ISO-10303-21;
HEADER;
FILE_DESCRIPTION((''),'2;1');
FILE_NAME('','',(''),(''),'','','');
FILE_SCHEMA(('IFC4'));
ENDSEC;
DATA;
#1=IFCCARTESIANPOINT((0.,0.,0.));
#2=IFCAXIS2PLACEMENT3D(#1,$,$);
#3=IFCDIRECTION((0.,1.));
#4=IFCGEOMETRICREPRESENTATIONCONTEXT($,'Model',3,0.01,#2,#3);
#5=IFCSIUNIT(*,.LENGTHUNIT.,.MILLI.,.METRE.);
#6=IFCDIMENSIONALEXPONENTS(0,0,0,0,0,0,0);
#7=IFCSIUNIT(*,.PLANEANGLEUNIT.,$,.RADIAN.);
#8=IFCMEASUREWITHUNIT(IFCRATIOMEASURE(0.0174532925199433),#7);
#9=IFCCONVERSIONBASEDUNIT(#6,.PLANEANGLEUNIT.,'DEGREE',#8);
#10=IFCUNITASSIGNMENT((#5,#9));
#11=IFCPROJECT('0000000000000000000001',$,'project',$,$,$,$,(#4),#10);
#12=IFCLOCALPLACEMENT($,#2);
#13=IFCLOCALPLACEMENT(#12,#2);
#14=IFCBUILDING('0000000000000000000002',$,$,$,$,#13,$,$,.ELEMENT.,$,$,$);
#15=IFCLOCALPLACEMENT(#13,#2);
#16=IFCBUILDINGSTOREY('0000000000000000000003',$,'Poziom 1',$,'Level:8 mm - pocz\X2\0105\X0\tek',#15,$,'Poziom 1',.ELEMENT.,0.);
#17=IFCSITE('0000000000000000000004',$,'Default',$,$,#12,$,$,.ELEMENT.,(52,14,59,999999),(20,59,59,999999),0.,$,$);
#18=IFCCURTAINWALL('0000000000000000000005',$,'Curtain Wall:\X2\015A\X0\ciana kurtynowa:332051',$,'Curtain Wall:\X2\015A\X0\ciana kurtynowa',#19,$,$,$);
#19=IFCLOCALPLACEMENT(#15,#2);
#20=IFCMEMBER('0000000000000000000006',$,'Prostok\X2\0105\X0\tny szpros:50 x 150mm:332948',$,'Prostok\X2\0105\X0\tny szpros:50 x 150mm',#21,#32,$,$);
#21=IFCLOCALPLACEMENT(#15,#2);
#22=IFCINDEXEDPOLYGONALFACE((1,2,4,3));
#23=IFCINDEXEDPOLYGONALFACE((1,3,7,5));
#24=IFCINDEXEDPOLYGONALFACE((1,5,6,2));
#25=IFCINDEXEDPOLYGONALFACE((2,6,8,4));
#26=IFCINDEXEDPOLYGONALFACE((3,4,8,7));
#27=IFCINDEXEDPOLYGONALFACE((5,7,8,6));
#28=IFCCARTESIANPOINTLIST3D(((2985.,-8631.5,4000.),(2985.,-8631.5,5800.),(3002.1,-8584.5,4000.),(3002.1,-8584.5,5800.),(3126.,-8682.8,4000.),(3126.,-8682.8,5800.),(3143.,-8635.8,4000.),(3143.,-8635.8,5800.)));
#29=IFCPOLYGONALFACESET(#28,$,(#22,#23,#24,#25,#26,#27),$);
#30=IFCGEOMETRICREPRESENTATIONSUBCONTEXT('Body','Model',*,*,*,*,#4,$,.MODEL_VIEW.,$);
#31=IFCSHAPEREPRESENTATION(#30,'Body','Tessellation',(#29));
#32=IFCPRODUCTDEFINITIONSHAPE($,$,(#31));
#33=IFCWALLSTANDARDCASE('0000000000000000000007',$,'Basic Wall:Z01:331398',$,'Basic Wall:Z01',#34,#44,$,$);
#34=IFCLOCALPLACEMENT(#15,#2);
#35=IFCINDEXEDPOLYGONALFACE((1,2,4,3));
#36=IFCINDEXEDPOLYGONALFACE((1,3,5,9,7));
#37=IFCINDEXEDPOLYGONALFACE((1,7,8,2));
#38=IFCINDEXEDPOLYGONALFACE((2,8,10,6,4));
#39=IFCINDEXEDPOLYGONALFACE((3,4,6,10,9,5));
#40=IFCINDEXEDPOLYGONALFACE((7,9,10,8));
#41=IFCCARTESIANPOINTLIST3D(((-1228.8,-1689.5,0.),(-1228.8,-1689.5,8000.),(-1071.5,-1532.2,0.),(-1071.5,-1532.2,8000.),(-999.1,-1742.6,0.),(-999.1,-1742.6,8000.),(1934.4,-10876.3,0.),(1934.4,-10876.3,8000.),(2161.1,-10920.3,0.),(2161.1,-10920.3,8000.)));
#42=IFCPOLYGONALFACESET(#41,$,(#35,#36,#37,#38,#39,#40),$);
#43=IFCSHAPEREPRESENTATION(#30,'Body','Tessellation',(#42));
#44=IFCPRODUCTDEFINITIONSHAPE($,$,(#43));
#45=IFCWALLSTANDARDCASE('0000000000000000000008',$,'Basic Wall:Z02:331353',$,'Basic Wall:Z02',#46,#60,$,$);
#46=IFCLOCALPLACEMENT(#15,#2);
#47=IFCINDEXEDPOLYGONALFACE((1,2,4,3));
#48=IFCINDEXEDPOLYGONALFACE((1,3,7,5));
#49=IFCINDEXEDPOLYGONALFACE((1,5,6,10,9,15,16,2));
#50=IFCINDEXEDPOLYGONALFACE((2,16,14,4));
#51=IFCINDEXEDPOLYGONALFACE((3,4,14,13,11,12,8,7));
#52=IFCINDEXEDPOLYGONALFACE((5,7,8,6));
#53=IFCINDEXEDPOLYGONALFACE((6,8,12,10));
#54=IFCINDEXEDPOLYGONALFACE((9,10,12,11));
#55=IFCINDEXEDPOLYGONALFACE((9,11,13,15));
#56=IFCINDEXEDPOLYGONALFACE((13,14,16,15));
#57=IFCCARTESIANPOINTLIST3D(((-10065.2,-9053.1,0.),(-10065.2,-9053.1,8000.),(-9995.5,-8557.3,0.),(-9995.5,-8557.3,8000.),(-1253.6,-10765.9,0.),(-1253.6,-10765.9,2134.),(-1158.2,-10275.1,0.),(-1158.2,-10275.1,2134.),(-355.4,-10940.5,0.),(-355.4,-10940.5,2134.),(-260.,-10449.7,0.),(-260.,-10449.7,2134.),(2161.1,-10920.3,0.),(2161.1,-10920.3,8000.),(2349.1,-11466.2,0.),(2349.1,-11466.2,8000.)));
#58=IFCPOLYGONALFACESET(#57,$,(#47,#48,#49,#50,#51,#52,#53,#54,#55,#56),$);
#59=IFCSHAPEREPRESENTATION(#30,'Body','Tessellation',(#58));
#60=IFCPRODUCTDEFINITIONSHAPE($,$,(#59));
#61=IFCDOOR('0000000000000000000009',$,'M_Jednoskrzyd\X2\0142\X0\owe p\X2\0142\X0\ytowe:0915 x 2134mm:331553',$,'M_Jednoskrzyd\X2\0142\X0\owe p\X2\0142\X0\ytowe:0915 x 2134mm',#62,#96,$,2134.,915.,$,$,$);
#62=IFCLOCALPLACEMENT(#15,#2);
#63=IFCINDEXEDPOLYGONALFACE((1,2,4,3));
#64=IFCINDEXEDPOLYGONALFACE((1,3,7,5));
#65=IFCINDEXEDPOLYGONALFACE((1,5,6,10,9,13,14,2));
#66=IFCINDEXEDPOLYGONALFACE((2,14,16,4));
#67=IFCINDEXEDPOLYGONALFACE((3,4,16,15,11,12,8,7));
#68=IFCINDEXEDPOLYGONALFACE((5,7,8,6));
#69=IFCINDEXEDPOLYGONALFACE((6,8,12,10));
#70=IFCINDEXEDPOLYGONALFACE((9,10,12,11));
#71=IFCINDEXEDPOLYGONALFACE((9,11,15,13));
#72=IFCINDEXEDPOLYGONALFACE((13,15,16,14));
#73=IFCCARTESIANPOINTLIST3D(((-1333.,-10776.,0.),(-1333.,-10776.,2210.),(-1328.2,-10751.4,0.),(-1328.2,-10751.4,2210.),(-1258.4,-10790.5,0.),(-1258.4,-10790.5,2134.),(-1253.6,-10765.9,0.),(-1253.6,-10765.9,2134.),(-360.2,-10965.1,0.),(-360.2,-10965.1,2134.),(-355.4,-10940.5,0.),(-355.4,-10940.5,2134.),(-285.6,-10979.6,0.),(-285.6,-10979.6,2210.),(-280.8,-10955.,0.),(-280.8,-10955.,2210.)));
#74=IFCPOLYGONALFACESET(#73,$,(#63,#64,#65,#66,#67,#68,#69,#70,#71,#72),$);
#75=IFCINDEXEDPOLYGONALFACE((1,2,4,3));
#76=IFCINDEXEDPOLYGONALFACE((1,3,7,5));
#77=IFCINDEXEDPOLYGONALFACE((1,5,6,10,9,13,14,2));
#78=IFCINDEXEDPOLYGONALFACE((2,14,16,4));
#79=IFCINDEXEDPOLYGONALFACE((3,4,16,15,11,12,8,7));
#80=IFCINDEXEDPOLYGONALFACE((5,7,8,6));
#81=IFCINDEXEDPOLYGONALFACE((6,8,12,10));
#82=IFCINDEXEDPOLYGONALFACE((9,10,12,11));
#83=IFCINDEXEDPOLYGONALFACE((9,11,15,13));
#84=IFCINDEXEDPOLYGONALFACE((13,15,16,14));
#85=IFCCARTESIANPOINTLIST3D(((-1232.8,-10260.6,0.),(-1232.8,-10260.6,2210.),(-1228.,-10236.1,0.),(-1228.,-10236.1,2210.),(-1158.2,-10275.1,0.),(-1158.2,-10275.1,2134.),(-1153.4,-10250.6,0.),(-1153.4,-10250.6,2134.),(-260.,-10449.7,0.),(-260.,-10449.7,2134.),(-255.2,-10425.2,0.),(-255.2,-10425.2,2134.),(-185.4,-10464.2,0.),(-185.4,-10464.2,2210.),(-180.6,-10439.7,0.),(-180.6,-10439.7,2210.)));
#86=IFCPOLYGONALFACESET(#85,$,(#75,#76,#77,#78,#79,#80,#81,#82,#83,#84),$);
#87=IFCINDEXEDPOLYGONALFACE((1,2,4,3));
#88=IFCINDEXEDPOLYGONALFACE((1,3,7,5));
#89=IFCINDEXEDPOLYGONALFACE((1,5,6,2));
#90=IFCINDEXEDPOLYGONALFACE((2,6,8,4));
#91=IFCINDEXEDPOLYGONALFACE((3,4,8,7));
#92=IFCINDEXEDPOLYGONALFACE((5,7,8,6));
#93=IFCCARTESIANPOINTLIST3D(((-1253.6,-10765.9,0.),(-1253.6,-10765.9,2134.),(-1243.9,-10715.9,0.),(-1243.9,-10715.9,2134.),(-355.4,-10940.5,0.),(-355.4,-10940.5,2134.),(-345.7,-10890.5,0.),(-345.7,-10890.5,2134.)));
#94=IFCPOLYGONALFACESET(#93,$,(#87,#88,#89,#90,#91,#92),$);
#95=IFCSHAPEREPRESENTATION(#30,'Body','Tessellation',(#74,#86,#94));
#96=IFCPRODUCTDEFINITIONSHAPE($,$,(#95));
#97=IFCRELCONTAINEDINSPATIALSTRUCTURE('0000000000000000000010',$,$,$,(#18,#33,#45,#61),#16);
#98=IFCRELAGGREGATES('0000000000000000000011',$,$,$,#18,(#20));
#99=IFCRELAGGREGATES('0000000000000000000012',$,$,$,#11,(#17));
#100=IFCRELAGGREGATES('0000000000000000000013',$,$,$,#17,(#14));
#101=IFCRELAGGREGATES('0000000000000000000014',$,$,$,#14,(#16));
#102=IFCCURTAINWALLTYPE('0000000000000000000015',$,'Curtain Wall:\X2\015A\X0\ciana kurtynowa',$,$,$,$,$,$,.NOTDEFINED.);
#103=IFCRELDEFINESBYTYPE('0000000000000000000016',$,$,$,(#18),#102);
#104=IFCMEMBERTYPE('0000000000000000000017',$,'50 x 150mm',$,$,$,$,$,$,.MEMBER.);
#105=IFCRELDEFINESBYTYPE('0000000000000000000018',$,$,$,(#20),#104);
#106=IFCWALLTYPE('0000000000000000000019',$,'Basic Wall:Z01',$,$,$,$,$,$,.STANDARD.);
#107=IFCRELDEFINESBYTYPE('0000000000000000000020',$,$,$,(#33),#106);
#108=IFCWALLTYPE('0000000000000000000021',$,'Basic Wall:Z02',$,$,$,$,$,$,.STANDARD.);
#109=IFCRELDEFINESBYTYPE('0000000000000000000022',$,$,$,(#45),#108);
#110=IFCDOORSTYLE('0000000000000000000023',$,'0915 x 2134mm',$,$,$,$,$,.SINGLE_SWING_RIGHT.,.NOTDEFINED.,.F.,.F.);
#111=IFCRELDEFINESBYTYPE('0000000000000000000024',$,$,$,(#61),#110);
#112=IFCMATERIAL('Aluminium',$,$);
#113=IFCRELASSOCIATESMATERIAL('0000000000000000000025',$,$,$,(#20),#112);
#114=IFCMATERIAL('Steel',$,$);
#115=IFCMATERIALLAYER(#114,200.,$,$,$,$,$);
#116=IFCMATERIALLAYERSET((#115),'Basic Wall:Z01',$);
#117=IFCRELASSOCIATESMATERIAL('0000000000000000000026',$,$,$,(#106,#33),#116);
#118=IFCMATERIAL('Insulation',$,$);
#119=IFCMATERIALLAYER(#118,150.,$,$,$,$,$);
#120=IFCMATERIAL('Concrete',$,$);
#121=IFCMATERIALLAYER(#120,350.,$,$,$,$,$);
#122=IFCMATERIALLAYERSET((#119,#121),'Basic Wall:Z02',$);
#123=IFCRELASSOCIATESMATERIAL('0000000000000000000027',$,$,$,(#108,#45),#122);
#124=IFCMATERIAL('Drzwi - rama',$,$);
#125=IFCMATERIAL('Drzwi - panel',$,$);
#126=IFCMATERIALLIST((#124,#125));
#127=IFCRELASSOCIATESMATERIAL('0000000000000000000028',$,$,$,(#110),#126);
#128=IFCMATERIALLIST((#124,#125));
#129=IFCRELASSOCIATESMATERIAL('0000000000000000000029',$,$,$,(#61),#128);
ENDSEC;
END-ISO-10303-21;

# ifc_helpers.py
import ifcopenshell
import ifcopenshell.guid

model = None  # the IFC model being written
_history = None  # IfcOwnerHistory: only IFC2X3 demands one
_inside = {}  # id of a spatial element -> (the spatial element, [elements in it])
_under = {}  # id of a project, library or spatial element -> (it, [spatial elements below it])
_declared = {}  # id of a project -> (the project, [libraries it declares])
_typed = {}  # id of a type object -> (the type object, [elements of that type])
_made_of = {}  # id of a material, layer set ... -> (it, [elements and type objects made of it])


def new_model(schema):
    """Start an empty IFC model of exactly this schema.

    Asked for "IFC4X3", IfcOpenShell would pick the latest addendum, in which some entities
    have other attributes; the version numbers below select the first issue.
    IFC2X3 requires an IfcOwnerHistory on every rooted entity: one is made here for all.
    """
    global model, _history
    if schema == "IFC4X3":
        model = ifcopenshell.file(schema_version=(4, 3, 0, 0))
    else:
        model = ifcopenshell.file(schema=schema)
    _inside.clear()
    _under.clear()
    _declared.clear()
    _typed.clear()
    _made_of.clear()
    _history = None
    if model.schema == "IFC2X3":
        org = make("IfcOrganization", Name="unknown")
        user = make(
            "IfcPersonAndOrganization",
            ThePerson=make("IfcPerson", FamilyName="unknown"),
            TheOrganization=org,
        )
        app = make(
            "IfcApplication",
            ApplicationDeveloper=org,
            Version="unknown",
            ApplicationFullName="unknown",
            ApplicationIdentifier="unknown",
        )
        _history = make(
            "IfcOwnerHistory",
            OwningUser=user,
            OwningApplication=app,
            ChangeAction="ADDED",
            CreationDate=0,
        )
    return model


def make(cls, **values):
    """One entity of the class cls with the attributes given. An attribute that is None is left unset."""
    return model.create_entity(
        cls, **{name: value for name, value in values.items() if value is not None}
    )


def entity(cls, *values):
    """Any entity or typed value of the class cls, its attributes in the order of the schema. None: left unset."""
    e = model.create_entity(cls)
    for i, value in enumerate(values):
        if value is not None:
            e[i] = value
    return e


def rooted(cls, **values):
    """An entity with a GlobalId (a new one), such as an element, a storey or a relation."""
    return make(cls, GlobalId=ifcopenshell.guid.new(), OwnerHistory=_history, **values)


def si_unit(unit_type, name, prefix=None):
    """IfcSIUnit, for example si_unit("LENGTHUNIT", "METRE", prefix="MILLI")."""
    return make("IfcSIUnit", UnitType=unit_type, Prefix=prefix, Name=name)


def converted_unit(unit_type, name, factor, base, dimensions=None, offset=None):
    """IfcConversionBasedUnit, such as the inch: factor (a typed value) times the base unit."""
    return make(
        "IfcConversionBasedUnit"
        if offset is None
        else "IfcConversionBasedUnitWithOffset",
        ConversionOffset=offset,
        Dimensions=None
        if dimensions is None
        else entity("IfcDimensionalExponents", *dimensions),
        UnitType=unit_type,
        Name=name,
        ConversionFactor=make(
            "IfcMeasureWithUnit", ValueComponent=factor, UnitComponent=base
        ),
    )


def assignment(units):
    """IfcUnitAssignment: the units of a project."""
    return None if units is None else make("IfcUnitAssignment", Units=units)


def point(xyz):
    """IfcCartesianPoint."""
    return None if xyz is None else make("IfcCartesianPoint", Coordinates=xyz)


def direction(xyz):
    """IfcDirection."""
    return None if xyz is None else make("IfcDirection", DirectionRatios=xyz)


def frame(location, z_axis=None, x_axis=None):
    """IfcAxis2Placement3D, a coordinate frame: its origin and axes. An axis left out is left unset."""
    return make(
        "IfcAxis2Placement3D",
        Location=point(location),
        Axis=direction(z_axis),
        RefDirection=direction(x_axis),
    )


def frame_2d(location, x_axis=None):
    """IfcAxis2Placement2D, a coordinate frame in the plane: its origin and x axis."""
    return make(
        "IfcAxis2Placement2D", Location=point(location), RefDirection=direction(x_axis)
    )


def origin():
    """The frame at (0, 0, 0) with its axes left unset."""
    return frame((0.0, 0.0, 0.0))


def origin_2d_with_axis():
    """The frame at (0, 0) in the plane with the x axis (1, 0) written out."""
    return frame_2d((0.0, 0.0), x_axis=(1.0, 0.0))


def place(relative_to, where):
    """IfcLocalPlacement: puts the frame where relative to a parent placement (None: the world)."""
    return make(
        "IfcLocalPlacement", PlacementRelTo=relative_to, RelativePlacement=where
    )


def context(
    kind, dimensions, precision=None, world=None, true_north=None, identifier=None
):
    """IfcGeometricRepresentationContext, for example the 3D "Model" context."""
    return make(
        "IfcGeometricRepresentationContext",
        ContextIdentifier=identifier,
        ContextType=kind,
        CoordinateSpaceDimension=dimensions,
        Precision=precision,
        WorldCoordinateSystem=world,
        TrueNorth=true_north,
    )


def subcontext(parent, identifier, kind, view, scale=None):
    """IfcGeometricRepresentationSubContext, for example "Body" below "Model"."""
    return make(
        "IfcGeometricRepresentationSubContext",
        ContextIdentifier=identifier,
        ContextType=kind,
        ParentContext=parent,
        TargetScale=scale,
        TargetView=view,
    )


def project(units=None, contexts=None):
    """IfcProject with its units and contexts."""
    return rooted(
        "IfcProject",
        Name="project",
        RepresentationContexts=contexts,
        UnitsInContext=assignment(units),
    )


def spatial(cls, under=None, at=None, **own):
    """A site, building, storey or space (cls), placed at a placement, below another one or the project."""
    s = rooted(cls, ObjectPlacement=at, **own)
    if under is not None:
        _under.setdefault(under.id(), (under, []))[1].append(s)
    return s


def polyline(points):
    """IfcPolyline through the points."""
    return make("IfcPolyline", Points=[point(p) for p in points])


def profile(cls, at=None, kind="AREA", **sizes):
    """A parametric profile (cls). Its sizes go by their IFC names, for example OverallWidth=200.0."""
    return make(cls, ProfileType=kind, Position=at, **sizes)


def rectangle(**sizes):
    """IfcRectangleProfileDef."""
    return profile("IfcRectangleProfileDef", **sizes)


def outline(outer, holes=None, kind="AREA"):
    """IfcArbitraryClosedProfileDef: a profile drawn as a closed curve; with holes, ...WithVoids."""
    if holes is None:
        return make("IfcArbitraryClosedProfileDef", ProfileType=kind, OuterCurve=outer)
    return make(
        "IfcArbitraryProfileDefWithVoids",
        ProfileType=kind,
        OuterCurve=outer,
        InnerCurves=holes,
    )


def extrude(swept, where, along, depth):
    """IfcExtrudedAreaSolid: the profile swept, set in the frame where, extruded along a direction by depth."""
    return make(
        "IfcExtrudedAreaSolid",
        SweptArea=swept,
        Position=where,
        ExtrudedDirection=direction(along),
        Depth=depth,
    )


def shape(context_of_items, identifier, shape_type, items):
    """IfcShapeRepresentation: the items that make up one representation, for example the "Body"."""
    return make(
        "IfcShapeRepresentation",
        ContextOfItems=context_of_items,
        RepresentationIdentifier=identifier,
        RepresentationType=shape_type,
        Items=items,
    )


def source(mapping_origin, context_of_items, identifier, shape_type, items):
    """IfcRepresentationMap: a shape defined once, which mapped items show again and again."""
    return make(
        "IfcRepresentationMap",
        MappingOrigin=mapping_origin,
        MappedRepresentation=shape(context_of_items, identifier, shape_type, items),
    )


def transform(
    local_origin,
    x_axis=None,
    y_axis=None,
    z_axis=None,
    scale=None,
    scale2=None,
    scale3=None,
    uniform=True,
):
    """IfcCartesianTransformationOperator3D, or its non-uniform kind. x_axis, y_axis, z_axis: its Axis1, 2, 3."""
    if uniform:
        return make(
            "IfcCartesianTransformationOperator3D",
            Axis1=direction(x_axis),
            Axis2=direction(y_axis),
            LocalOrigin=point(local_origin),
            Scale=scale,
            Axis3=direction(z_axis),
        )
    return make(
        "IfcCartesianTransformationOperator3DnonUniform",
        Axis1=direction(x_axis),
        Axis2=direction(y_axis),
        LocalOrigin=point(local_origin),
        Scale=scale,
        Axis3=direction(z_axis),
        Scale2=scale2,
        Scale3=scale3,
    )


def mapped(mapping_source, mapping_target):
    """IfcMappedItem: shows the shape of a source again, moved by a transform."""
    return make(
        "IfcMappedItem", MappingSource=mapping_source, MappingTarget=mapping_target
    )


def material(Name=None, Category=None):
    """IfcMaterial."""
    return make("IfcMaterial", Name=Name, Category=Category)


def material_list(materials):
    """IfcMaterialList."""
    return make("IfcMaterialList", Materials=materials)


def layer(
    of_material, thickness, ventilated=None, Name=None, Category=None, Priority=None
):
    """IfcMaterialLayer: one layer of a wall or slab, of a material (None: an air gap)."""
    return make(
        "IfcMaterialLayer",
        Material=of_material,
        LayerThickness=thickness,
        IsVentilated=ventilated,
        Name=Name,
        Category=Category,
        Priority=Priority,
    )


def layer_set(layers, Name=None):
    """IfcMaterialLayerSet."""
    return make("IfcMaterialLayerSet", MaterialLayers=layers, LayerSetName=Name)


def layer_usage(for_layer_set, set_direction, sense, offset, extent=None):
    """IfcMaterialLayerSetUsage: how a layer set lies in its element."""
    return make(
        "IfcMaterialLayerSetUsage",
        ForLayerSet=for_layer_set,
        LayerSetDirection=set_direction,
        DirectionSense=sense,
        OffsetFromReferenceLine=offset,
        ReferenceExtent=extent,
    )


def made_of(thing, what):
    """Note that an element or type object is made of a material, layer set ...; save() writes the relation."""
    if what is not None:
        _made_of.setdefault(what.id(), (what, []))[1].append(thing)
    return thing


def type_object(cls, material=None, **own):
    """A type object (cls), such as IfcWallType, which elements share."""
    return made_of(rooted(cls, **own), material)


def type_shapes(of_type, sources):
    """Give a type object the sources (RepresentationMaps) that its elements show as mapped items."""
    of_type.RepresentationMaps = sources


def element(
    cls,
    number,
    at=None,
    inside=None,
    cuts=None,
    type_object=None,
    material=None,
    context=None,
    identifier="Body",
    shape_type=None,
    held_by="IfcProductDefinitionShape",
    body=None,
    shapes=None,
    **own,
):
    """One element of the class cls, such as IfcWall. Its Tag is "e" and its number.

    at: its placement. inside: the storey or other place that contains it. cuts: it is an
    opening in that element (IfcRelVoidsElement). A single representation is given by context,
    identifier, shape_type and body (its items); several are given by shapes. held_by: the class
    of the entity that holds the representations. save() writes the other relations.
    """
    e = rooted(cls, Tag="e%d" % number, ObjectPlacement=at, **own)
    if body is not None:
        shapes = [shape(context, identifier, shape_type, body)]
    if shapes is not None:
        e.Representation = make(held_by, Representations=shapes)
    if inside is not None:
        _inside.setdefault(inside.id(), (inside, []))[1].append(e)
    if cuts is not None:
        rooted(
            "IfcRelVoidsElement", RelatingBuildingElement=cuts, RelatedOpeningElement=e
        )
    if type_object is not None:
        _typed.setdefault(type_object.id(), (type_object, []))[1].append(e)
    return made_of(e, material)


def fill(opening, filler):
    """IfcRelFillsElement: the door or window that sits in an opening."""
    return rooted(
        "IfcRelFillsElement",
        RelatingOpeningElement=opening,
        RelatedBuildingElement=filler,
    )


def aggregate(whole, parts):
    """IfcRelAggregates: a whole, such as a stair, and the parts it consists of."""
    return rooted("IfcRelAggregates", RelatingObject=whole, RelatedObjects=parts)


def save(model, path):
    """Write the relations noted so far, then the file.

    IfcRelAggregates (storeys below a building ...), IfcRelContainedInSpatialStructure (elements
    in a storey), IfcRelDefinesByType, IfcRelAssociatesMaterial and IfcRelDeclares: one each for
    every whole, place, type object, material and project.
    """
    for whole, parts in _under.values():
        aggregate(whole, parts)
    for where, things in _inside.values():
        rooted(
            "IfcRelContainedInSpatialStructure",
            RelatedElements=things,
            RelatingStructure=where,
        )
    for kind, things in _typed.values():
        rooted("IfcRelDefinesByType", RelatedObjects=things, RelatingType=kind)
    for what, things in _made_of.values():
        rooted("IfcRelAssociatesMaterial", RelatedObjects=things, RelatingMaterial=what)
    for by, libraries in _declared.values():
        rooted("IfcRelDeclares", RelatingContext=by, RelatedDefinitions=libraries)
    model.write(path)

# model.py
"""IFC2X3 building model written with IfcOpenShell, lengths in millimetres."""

from ifc_helpers import new_model, entity, si_unit, converted_unit, direction, frame, frame_2d, origin, origin_2d_with_axis, place, context, subcontext, project, spatial, polyline, rectangle, outline, extrude, source, transform, mapped, material, material_list, layer, layer_set, layer_usage, type_object, type_shapes, element, fill, aggregate, save


model = new_model("IFC2X3")

# Units and contexts
model_context = context("Model", 3, precision=0.01, world=origin(), true_north=direction((0.0, 1.0)))
body_context = subcontext(model_context, "Body", "Model", "MODEL_VIEW")
ifc_project = project(units=[si_unit("LENGTHUNIT", "METRE", prefix="MILLI"), converted_unit("PLANEANGLEUNIT", "DEGREE", entity("IfcRatioMeasure", 0.0174532925199433), si_unit("PLANEANGLEUNIT", "RADIAN"), dimensions=[0, 0, 0, 0, 0, 0, 0])], contexts=[model_context])

# Site, building, storey
site_placement = place(None, origin())
site = spatial("IfcSite", under=ifc_project, at=site_placement, Name="Default", CompositionType="ELEMENT", RefLatitude=(52, 14, 59, 999999), RefLongitude=(20, 59, 59, 999999), RefElevation=0.0)
building_placement = place(site_placement, origin())
building = spatial("IfcBuilding", under=site, at=building_placement, CompositionType="ELEMENT")
storey_placement = place(building_placement, origin())
storey = spatial("IfcBuildingStorey", under=building, at=storey_placement, Name="Poziom 1", ObjectType="Level:8 mm - początek", LongName="Poziom 1", CompositionType="ELEMENT", Elevation=0.0)

# Curtain wall, member
curtain_wall_type = type_object("IfcCurtainWallType", Name="Curtain Wall:Ściana kurtynowa", PredefinedType="NOTDEFINED")
curtain_wall_placement = place(storey_placement, origin())
curtain_wall = element("IfcCurtainWall", 1, at=curtain_wall_placement, inside=storey, type_object=curtain_wall_type, Name="Curtain Wall:Ściana kurtynowa:332051", ObjectType="Curtain Wall:Ściana kurtynowa")
ifc_material_1 = material(Name="Aluminium")
member_type_1 = type_object("IfcMemberType", Name="50 x 150mm", PredefinedType="MEMBER")
shared_shape_1 = source(origin(), body_context, "Body", "SweptSolid", [
    extrude(rectangle(XDim=150.0, YDim=50.0, at=origin_2d_with_axis()), frame((0.0, 0.0, -1800.0), z_axis=(0.0, 0.0, 1.0), x_axis=(0.0, -1.0, 0.0)), (0.0, 0.0, 1.0), 1800.0),
])
type_shapes(member_type_1, [shared_shape_1])
member_1_placement = place(storey_placement, frame((3064.0, -8633.7, 4000.0), z_axis=(0.0, 0.0, -1.0), x_axis=(0.341586, 0.939851, 0.0)))
member_1 = element("IfcMember", 2, at=member_1_placement, type_object=member_type_1, material=ifc_material_1, Name="Prostokątny szpros:50 x 150mm:332948", ObjectType="Prostokątny szpros:50 x 150mm", context=body_context, shape_type="MappedRepresentation", body=[
    mapped(shared_shape_1, transform((0.0, 0.0, 0.0), scale=1.0)),
])
aggregate(curtain_wall, [member_1])

# Wall
ifc_material_2 = material(Name="Steel")
ifc_layer_1 = layer(ifc_material_2, 200.0)
ifc_layer_set_1 = layer_set([ifc_layer_1], Name="Basic Wall:Z01")
ifc_layer_usage_1 = layer_usage(ifc_layer_set_1, "AXIS2", "NEGATIVE", 100.0)
wall_type_1 = type_object("IfcWallType", Name="Basic Wall:Z01", PredefinedType="STANDARD", material=ifc_layer_set_1)
wall_1_placement = place(storey_placement, frame((2066.5, -10952.9, 0.0), z_axis=(0.0, 0.0, 1.0), x_axis=(-0.325568, 0.945519, 0.0)))
element("IfcWallStandardCase", 3, at=wall_1_placement, inside=storey, type_object=wall_type_1, material=ifc_layer_usage_1, Name="Basic Wall:Z01:331398", ObjectType="Basic Wall:Z01", context=body_context, shape_type="SweptSolid", body=[
    extrude(outline(polyline([(9929.1, -100.0), (9831.5, 100.0), (115.5, 100.0), (0.0, -100.0), (9706.6, -100.0), (9929.1, -100.0)])), origin(), (0.0, 0.0, 1.0), 8000.0),
])

# Wall, opening, door
ifc_material_3 = material(Name="Insulation")
ifc_layer_2 = layer(ifc_material_3, 150.0)
ifc_material_4 = material(Name="Concrete")
ifc_layer_3 = layer(ifc_material_4, 350.0)
ifc_layer_set_2 = layer_set([ifc_layer_2, ifc_layer_3], Name="Basic Wall:Z02")
ifc_layer_usage_2 = layer_usage(ifc_layer_set_2, "AXIS2", "NEGATIVE", 250.0)
wall_type_2 = type_object("IfcWallType", Name="Basic Wall:Z02", PredefinedType="STANDARD", material=ifc_layer_set_2)
wall_2_placement = place(storey_placement, frame((-10043.2, -8802.7, 0.0), z_axis=(0.0, 0.0, 1.0), x_axis=(0.981627, -0.190809, 0.0)))
wall_2 = element("IfcWallStandardCase", 4, at=wall_2_placement, inside=storey, type_object=wall_type_2, material=ifc_layer_usage_2, Name="Basic Wall:Z02:331353", ObjectType="Basic Wall:Z02", context=body_context, shape_type="SweptSolid", body=[
    extrude(outline(polyline([(26.2, -250.0), (12672.8, -250.0), (12384.1, 250.0), (12153.2, 250.0), (0.0, 250.0), (26.2, -250.0)])), origin(), (0.0, 0.0, 1.0), 8000.0),
])
opening_placement = place(wall_2_placement, frame((9917.7, 250.0, 0.0)))
opening = element("IfcOpeningElement", 5, at=opening_placement, cuts=wall_2, ObjectType="Opening", context=body_context, shape_type="SweptSolid", body=[
    extrude(rectangle(XDim=915.0, YDim=2134.0, at=frame_2d((1067.0, 457.5), x_axis=(0.0, 1.0))), frame((0.0, 0.0, 0.0), z_axis=(0.0, -1.0, 0.0), x_axis=(0.0, 0.0, 1.0)), (0.0, 0.0, 1.0), 500.0),
])
ifc_material_5 = material(Name="Drzwi - rama")
ifc_material_6 = material(Name="Drzwi - panel")
ifc_material_list_1 = material_list([ifc_material_5, ifc_material_6])
ifc_material_list_2 = material_list([ifc_material_5, ifc_material_6])
door_style = type_object("IfcDoorStyle", Name="0915 x 2134mm", ConstructionType="NOTDEFINED", OperationType="SINGLE_SWING_RIGHT", ParameterTakesPrecedence=False, Sizeable=False, material=ifc_material_list_2)
shared_shape_2 = source(origin(), body_context, "Body", "SweptSolid", [
    extrude(outline(polyline([(-533.5, -1124.0), (533.5, -1124.0), (533.5, 1086.0), (457.5, 1086.0), (457.5, -1048.0), (-457.5, -1048.0), (-457.5, 1086.0), (-533.5, 1086.0), (-533.5, -1124.0)])), frame((457.5, 500.0, 1086.0), z_axis=(0.0, 1.0, 0.0), x_axis=(1.0, 0.0, 0.0)), (0.0, 0.0, 1.0), 25.0),
    extrude(outline(polyline([(-1124.0, -533.5), (1086.0, -533.5), (1086.0, -457.5), (-1048.0, -457.5), (-1048.0, 457.5), (1086.0, 457.5), (1086.0, 533.5), (-1124.0, 533.5), (-1124.0, -533.5)])), frame((457.5, -25.0, 1086.0), z_axis=(0.0, 1.0, 0.0), x_axis=(0.0, 0.0, -1.0)), (0.0, 0.0, 1.0), 25.0),
    extrude(rectangle(XDim=51.0, YDim=915.0, at=frame_2d((0.0, 0.0), x_axis=(1.0, 0.0))), frame((457.5, 474.5, 0.0), z_axis=(0.0, 0.0, 1.0), x_axis=(0.0, 1.0, 0.0)), (0.0, 0.0, 1.0), 2134.0),
])
type_shapes(door_style, [shared_shape_2])
door_placement = place(opening_placement, frame((0.0, 0.0, 0.0), z_axis=(0.0, 0.0, 1.0), x_axis=(-1.0, 0.0, 0.0)))
door = element("IfcDoor", 6, at=door_placement, inside=storey, type_object=door_style, material=ifc_material_list_1, Name="M_Jednoskrzydłowe płytowe:0915 x 2134mm:331553", ObjectType="M_Jednoskrzydłowe płytowe:0915 x 2134mm", OverallHeight=2134.0, OverallWidth=915.0, context=body_context, shape_type="MappedRepresentation", body=[
    mapped(shared_shape_2, transform((0.0, 0.0, 0.0), scale=1.0)),
])
fill(opening, door)

save(model, "model.ifc")
